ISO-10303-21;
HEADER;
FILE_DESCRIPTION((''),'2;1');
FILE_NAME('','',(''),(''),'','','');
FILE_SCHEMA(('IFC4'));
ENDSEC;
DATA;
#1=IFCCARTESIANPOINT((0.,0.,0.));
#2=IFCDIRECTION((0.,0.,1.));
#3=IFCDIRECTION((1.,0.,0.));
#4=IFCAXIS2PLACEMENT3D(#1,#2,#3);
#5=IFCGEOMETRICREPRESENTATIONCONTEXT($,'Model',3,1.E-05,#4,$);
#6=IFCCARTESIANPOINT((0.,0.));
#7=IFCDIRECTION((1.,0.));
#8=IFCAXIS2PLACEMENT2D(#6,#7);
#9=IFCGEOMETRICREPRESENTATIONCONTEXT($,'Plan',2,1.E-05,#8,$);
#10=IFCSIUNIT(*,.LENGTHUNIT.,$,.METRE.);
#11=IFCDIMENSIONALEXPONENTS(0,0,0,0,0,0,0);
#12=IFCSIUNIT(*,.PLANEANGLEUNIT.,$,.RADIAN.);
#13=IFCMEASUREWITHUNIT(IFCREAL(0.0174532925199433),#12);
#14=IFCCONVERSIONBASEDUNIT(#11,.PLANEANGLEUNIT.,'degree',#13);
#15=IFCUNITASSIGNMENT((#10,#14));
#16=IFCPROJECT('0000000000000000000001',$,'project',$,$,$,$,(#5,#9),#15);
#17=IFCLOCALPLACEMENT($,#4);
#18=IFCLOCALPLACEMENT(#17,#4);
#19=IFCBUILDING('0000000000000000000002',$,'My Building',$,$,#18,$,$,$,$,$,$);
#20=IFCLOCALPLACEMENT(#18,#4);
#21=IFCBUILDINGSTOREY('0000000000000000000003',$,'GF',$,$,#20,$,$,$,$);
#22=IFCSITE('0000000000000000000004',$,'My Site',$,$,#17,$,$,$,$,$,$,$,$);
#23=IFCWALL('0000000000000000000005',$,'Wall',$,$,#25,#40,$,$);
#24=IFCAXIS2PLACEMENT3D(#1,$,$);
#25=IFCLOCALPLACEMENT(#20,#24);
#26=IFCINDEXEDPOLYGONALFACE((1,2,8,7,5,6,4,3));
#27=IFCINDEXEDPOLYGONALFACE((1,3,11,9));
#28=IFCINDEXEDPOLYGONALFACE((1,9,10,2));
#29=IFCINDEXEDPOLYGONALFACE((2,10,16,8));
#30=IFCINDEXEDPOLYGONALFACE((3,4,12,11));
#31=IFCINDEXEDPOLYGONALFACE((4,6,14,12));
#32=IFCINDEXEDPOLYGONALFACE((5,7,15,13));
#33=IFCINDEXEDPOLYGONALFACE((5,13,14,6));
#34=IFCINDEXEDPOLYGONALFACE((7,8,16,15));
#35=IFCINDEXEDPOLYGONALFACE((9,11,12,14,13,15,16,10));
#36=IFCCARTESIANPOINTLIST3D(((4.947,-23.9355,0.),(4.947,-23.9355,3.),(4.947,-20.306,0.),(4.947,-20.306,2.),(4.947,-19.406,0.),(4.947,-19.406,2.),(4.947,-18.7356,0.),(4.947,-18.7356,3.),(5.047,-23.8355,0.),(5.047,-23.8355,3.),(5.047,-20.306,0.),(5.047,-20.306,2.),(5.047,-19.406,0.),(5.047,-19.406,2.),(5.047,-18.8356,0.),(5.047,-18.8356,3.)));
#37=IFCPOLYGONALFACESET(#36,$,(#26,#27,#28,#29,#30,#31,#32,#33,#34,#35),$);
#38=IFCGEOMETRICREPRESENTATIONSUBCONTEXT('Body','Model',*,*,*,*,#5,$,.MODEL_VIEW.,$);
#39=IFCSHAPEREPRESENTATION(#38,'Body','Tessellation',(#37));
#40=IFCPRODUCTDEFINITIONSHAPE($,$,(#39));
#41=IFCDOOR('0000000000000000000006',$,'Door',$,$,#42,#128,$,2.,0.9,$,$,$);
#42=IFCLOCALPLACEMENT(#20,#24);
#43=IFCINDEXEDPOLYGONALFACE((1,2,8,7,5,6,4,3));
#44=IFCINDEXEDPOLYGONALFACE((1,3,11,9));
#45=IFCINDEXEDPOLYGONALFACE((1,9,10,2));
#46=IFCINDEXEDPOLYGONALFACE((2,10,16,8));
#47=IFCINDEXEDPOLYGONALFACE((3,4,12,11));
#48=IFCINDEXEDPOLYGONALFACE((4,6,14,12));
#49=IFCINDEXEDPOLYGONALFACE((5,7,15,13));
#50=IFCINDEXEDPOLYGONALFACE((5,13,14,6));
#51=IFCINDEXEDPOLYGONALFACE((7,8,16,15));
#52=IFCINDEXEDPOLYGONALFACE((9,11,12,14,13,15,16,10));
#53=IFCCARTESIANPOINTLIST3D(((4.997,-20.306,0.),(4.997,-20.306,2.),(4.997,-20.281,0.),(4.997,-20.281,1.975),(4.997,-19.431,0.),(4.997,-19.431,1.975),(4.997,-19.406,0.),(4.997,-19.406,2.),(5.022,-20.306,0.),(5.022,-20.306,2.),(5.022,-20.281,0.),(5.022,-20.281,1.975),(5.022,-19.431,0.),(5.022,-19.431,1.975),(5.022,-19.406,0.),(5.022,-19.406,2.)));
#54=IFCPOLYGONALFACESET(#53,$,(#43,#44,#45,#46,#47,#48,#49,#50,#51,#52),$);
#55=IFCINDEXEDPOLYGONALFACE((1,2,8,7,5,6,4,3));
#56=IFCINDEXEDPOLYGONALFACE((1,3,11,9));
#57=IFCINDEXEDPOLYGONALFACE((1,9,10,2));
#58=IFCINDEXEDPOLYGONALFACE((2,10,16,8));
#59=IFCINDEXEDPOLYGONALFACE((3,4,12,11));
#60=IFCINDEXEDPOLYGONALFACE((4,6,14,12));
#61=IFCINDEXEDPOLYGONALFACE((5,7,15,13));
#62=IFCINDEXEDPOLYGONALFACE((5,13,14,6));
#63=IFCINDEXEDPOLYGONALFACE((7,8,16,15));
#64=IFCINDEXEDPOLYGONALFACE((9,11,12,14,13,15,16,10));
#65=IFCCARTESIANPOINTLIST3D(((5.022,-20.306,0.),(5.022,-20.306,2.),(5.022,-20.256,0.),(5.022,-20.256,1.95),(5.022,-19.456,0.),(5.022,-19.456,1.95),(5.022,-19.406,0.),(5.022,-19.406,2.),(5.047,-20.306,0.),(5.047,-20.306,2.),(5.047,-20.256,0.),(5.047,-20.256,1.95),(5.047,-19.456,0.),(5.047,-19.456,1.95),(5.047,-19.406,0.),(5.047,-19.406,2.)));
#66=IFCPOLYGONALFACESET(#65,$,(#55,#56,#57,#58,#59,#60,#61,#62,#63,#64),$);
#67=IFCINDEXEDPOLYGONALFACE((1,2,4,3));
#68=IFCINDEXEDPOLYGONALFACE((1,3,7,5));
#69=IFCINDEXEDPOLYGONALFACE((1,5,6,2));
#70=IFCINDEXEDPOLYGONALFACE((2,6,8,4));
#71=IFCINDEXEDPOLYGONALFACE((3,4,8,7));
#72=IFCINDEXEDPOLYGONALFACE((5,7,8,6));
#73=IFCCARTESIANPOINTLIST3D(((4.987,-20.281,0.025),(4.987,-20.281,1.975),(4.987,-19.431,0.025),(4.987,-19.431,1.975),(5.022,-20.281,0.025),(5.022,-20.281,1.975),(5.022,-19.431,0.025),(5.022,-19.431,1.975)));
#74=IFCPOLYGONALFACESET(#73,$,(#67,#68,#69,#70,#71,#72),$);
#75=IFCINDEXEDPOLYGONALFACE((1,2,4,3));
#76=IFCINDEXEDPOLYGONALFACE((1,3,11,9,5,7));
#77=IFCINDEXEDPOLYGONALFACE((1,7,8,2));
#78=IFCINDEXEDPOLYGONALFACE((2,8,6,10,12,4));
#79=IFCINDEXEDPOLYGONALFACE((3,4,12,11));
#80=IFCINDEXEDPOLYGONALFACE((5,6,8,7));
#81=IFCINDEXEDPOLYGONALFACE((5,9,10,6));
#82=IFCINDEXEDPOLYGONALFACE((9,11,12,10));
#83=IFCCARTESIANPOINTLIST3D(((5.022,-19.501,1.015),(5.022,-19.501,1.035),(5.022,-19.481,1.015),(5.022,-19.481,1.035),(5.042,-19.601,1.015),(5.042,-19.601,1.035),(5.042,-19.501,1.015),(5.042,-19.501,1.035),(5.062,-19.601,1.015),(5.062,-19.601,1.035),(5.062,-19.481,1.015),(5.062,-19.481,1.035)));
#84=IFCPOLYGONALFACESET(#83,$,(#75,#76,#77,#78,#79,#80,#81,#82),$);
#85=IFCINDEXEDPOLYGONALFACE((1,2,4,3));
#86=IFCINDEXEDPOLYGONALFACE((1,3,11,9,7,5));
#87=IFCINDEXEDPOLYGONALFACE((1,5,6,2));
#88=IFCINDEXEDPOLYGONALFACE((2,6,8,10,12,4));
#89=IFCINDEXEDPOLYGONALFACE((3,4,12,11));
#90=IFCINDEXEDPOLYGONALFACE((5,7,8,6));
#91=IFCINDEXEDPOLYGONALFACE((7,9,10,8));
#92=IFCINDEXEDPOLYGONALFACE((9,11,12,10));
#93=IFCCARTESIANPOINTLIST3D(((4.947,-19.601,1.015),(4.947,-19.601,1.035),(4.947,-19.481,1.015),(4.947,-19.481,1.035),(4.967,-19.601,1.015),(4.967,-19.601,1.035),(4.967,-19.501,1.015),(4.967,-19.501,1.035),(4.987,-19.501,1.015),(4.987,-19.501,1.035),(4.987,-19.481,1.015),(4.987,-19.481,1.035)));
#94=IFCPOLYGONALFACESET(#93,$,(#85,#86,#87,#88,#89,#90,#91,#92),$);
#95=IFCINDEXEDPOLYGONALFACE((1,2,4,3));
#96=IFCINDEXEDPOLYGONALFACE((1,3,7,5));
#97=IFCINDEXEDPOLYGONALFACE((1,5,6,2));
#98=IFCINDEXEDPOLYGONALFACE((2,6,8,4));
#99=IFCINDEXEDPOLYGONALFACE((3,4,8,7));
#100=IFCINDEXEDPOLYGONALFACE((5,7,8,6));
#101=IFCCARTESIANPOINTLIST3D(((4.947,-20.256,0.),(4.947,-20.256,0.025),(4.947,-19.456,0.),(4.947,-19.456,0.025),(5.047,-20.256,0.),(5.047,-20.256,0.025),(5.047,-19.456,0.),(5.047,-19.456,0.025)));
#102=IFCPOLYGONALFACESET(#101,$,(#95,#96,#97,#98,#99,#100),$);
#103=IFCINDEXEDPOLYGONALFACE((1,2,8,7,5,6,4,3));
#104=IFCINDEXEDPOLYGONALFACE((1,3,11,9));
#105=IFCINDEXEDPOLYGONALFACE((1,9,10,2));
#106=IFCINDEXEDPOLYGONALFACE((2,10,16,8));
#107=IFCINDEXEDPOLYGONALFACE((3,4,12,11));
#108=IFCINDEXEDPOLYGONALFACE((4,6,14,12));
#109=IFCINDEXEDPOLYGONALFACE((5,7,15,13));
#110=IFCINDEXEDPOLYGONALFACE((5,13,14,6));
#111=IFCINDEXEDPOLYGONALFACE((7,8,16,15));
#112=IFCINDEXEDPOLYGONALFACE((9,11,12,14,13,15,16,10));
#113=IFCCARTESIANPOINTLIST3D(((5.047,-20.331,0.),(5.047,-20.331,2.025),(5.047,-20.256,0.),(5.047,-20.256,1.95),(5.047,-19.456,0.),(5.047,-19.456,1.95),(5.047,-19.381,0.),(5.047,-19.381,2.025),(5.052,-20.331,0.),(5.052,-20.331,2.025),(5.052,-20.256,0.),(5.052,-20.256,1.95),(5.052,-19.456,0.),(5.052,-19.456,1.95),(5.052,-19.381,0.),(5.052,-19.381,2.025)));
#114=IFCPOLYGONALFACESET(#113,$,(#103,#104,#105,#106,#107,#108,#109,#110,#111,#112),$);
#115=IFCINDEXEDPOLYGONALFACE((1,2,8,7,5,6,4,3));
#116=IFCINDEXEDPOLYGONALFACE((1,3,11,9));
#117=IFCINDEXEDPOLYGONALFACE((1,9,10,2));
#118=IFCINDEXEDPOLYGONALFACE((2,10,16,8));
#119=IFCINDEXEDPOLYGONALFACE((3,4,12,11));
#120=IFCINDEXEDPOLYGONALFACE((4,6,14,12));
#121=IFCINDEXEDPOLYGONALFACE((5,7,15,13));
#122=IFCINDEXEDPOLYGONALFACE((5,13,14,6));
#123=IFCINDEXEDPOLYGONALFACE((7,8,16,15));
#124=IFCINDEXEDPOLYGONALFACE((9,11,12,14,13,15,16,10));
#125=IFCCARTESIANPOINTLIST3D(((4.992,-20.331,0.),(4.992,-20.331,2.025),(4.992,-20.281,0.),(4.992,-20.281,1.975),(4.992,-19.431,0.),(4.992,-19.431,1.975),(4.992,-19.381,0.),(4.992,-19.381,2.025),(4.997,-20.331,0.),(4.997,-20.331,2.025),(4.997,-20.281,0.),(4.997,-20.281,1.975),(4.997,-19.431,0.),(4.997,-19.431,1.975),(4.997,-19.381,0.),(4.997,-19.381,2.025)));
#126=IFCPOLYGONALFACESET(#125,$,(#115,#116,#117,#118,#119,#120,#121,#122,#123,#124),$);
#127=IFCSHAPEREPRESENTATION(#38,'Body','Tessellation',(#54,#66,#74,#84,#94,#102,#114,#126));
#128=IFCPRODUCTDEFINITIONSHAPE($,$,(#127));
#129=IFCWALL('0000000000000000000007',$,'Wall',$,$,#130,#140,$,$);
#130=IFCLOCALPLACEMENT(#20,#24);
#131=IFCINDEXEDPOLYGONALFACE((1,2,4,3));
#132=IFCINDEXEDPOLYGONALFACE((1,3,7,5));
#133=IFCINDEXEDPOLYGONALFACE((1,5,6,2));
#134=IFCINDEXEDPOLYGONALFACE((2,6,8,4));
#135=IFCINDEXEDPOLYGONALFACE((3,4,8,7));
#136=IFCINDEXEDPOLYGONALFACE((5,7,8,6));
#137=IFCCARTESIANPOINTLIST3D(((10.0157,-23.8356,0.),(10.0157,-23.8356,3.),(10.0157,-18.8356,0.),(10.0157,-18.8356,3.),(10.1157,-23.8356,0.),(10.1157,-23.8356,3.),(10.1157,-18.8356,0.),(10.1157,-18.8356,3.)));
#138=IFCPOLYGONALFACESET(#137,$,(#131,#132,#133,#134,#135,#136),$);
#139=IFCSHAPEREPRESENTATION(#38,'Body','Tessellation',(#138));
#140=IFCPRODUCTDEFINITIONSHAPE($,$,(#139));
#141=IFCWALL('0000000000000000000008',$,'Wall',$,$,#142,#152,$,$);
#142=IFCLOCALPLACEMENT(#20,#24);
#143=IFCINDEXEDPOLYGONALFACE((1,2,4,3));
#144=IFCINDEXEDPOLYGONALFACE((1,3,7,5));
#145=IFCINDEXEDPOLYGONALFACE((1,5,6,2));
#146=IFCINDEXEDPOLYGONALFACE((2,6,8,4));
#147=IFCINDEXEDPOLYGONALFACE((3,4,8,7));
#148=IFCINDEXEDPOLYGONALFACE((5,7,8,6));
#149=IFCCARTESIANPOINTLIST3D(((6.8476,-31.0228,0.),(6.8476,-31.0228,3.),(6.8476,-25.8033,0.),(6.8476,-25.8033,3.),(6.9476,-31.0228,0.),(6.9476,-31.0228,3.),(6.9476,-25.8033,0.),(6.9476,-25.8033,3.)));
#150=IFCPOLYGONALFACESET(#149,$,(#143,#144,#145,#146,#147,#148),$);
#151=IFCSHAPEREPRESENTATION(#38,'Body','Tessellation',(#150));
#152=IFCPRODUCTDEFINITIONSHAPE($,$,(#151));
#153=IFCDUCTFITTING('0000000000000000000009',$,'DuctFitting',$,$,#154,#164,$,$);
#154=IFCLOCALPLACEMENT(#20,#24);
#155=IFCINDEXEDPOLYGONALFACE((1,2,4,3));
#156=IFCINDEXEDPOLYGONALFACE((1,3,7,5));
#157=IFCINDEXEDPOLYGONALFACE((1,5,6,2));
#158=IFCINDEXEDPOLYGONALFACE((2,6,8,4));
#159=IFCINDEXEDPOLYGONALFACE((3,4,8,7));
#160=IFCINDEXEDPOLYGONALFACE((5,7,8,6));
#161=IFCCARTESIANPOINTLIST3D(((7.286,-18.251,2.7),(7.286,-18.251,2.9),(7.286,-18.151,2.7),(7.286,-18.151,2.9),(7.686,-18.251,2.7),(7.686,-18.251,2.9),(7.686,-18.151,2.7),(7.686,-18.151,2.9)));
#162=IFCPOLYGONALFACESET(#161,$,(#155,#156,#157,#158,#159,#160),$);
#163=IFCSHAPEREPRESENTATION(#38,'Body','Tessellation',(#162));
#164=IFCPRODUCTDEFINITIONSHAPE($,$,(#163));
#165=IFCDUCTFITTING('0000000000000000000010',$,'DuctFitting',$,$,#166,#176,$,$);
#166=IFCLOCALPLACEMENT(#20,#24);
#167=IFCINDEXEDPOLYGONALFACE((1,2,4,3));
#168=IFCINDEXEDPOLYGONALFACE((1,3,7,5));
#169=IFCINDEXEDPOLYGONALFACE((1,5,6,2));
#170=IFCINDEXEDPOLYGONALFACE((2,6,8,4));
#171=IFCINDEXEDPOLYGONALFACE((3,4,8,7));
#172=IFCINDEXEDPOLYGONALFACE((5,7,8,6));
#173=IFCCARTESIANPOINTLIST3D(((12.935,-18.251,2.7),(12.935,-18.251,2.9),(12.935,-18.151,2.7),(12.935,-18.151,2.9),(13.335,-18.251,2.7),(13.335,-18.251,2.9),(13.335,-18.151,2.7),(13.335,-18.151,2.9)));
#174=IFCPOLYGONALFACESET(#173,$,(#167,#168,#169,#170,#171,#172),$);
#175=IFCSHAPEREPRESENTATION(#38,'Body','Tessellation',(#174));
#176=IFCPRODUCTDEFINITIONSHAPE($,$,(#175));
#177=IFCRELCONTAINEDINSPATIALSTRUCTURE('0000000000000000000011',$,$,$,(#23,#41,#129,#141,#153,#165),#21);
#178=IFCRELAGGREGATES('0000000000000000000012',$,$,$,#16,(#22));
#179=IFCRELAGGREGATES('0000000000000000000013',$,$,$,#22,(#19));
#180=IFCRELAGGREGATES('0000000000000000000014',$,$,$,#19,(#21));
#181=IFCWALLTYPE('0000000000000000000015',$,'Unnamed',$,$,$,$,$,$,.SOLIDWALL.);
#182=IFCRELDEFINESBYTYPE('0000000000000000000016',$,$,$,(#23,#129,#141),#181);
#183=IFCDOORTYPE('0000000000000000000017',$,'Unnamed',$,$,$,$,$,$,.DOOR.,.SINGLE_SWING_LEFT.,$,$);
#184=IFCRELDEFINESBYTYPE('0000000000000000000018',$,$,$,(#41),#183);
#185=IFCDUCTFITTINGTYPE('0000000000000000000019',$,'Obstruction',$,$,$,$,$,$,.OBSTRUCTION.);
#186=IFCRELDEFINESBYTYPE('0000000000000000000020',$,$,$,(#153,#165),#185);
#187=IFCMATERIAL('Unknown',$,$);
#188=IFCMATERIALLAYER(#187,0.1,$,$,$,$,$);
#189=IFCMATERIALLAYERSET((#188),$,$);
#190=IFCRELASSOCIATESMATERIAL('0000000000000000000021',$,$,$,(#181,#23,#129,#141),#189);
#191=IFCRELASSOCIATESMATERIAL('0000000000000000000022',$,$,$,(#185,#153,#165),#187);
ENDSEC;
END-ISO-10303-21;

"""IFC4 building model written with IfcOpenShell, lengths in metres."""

from ifc_helpers import new_model, entity, si_unit, converted_unit, frame, origin_with_axes, origin_2d_with_axis, place, context, subcontext, project, spatial, line, indexed_curve, rectangle, outline, extrude, shape, source, transform, mapped, material, layer, layer_set, layer_usage, material_profile, profile_set, profile_usage, type_object, type_shapes, element, fill, save


model = new_model("IFC4")

# Units and contexts
model_context = context("Model", 3, precision=1e-05, world=origin_with_axes())
plan_context = context("Plan", 2, precision=1e-05, world=origin_2d_with_axis())
body_context_1 = subcontext(model_context, "Body", "Model", "MODEL_VIEW")
body_context_2 = subcontext(plan_context, "Body", "Plan", "PLAN_VIEW")
ifc_project = project(units=[si_unit("LENGTHUNIT", "METRE"), converted_unit("PLANEANGLEUNIT", "degree", entity("IfcReal", 0.0174532925199433), si_unit("PLANEANGLEUNIT", "RADIAN"), dimensions=[0, 0, 0, 0, 0, 0, 0])], contexts=[model_context, plan_context])

# Site, building, storey
site_placement = place(None, origin_with_axes())
site = spatial("IfcSite", under=ifc_project, at=site_placement, Name="My Site")
building_placement = place(site_placement, origin_with_axes())
building = spatial("IfcBuilding", under=site, at=building_placement, Name="My Building")
storey_placement = place(building_placement, origin_with_axes())
storey = spatial("IfcBuildingStorey", under=building, at=storey_placement, Name="GF")

# Shared definitions
ifc_material = material(Name="Unknown")

# Shared definitions
ifc_layer_1 = layer(ifc_material, 0.1)
ifc_layer_set_1 = layer_set([ifc_layer_1])
wall_type = type_object("IfcWallType", Name="Unnamed", PredefinedType="SOLIDWALL", material=ifc_layer_set_1)

# Shared definitions
shared_shape_1 = source(origin_with_axes(), body_context_1, "Body", "SweptSolid", [
    extrude(outline(indexed_curve([(0.0, 0.0), (0.9, 0.0), (0.9, 2.0), (0.0, 2.0)], segments=[line(1, 2, 3, 4, 1)])), frame((0.0, -0.6, 0.0), z_axis=(0.0, -1.0, 0.0), x_axis=(1.0, 0.0, 0.0)), (0.0, 0.0, -1.0), 1.2),
])
door_type = type_object("IfcDoorType", Name="Unnamed", OperationType="SINGLE_SWING_LEFT", PredefinedType="DOOR")
shared_shape_2 = source(origin_with_axes(), body_context_1, "Body", "SweptSolid", [
    extrude(outline(indexed_curve([(0.0, 0.0), (0.0, 2.0), (0.9, 2.0), (0.9, 0.0), (0.875, 0.0), (0.875, 1.975), (0.025, 1.975), (0.025, 0.0)], segments=[line(1, 2, 3, 4, 5, 6, 7, 8, 1)])), frame((0.0, 0.025, 0.0), z_axis=(0.0, -1.0, 0.0), x_axis=(1.0, 0.0, 0.0)), (0.0, 0.0, -1.0), 0.025),
    extrude(outline(indexed_curve([(0.0, 0.0), (0.0, 2.0), (0.9, 2.0), (0.9, 0.0), (0.85, 0.0), (0.85, 1.95), (0.05, 1.95), (0.05, 0.0)], segments=[line(1, 2, 3, 4, 5, 6, 7, 8, 1)])), frame((0.0, 0.0, 0.0), z_axis=(0.0, -1.0, 0.0), x_axis=(1.0, 0.0, 0.0)), (0.0, 0.0, -1.0), 0.025),
    extrude(outline(indexed_curve([(0.0, 0.0), (0.85, 0.0), (0.85, 0.035), (0.0, 0.035)], segments=[line(1, 2, 3, 4, 1)])), frame((0.025, 0.025, 0.025), z_axis=(0.0, 0.0, 1.0), x_axis=(1.0, 0.0, 0.0)), (0.0, 0.0, 1.0), 1.95),
    extrude(outline(indexed_curve([(0.0, 0.0), (0.0, -0.04), (-0.12, -0.04), (-0.12, -0.02), (-0.02, -0.02), (-0.02, 0.0)], segments=[line(1, 2, 3, 4, 5, 6, 1)])), frame((0.825, 0.025, 1.015), z_axis=(0.0, 0.0, 1.0), x_axis=(1.0, 0.0, 0.0)), (0.0, 0.0, 1.0), 0.02),
    extrude(outline(indexed_curve([(0.0, 0.0), (0.0, 0.04), (-0.12, 0.04), (-0.12, 0.02), (-0.02, 0.02), (-0.02, 0.0)], segments=[line(1, 2, 3, 4, 5, 6, 1)])), frame((0.825, 0.06, 1.015), z_axis=(0.0, 0.0, 1.0), x_axis=(1.0, 0.0, 0.0)), (0.0, 0.0, 1.0), 0.02),
    extrude(outline(indexed_curve([(0.0, 0.0), (0.8, 0.0), (0.8, 0.1), (0.0, 0.1)], segments=[line(1, 2, 3, 4, 1)])), frame((0.05, 0.0, 0.0), z_axis=(0.0, 0.0, 1.0), x_axis=(1.0, 0.0, 0.0)), (0.0, 0.0, 1.0), 0.025),
    extrude(outline(indexed_curve([(0.0, 0.0), (0.0, 2.025), (0.95, 2.025), (0.95, 0.0), (0.875, 0.0), (0.875, 1.95), (0.075, 1.95), (0.075, 0.0)], segments=[line(1, 2, 3, 4, 5, 6, 7, 8, 1)])), frame((-0.025, -0.005, 0.0), z_axis=(0.0, -1.0, 0.0), x_axis=(1.0, 0.0, 0.0)), (0.0, 0.0, -1.0), 0.005),
    extrude(outline(indexed_curve([(0.0, 0.0), (0.0, 2.025), (0.95, 2.025), (0.95, 0.0), (0.9, 0.0), (0.9, 1.975), (0.05, 1.975), (0.05, 0.0)], segments=[line(1, 2, 3, 4, 5, 6, 7, 8, 1)])), frame((-0.025, 0.05, 0.0), z_axis=(0.0, -1.0, 0.0), x_axis=(1.0, 0.0, 0.0)), (0.0, 0.0, -1.0), 0.005),
])
shared_shape_3 = source(origin_with_axes(), body_context_2, "Body", "Curve2D", [
    entity("IfcIndexedPolyCurve", entity("IfcCartesianPointList2D", [[0.0, 0.0], [0.0, 0.05], [0.025, 0.05], [0.025, 0.025], [0.05, 0.025], [0.05, 0.0]]), [entity("IfcLineIndex", [1, 2, 3, 4, 5, 6, 1])]),
    entity("IfcIndexedPolyCurve", entity("IfcCartesianPointList2D", [[0.9, 0.0], [0.9, 0.05], [0.875, 0.05], [0.875, 0.025], [0.85, 0.025], [0.85, 0.0]]), [entity("IfcLineIndex", [1, 2, 3, 4, 5, 6, 1])]),
    entity("IfcTrimmedCurve", entity("IfcEllipse", entity("IfcAxis2Placement2D", entity("IfcCartesianPoint", [0.06, 0.05]), entity("IfcDirection", [1.0, 0.0])), 0.815, 0.85), [entity("IfcCartesianPoint", [0.875, 0.05])], [entity("IfcCartesianPoint", [0.06, 0.9])], True, "CARTESIAN"),
    entity("IfcIndexedPolyCurve", entity("IfcCartesianPointList2D", [[0.025, 0.05], [0.06, 0.05], [0.06, 0.9], [0.025, 0.9]]), [entity("IfcLineIndex", [1, 2, 3, 4, 1])]),
])
type_shapes(door_type, [shared_shape_2, shared_shape_3])

# Wall, opening, door
ifc_layer_usage_1 = layer_usage(ifc_layer_set_1, "AXIS2", "POSITIVE", 0.0)
wall_1_placement = place(storey_placement, frame((5.047, -23.8355, 0.0), z_axis=(0.0, 0.0, 1.0), x_axis=(0.0, 1.0, 0.0)))
wall_1 = element("IfcWall", 1, at=wall_1_placement, inside=storey, type_object=wall_type, material=ifc_layer_usage_1, Name="Wall", context=body_context_1, shape_type="SweptSolid", body=[
    extrude(outline(indexed_curve([(0.0, 0.0), (-0.1, 0.1), (5.1, 0.1), (5.0, 0.0)], segments=[line(1, 2, 3, 4, 1)])), origin_with_axes(), (0.0, 0.0, 1.0), 3.0),
])
opening_1_placement = place(wall_1_placement, frame((3.5295, 0.0, 0.0), z_axis=(0.0, 0.0, 1.0), x_axis=(1.0, 0.0, 0.0)))
opening_1 = element("IfcOpeningElement", 2, at=opening_1_placement, cuts=wall_1, PredefinedType="OPENING", context=body_context_1, shape_type="MappedRepresentation", body=[
    mapped(shared_shape_1, transform((0.0, 0.0, 0.0), x_axis=(1.0, 0.0, 0.0), y_axis=(0.0, 1.0, 0.0), z_axis=(0.0, 0.0, 1.0), scale=1.0)),
])
door_1_placement = place(opening_1_placement, frame((0.0, 0.0, 0.0), z_axis=(0.0, 0.0, 1.0), x_axis=(1.0, 0.0, 0.0)))
door_1 = element("IfcDoor", 3, at=door_1_placement, inside=storey, type_object=door_type, Name="Door", OverallHeight=2.0, OverallWidth=0.9, shapes=[
    shape(body_context_1, "Body", "MappedRepresentation", [mapped(shared_shape_2, transform((0.0, 0.0, 0.0), x_axis=(1.0, 0.0, 0.0), y_axis=(0.0, 1.0, 0.0), z_axis=(0.0, 0.0, 1.0), scale=1.0))]),
    shape(body_context_2, "Body", "MappedRepresentation", [mapped(shared_shape_3, transform((0.0, 0.0, 0.0), x_axis=(1.0, 0.0, 0.0), y_axis=(0.0, 1.0, 0.0), z_axis=(0.0, 0.0, 1.0), scale=1.0))]),
])
fill(opening_1, door_1)

# Walls
ifc_layer_usage_2 = layer_usage(ifc_layer_set_1, "AXIS2", "POSITIVE", 0.0)
wall_2_placement = place(storey_placement, frame((10.0157, -18.8356, 0.0), z_axis=(0.0, 0.0, 1.0), x_axis=(0.0, -1.0, 0.0)))
element("IfcWall", 4, at=wall_2_placement, inside=storey, type_object=wall_type, material=ifc_layer_usage_2, Name="Wall", context=body_context_1, shape_type="SweptSolid", body=[
    extrude(outline(indexed_curve([(0.0, 0.0), (0.0, 0.1), (5.0, 0.1), (5.0, 0.0)], segments=[line(1, 2, 3, 4, 1)])), origin_with_axes(), (0.0, 0.0, 1.0), 3.0),
])
ifc_layer_usage_3 = layer_usage(ifc_layer_set_1, "AXIS2", "POSITIVE", 0.0)
wall_3_placement = place(storey_placement, frame((6.8476, -25.8033, 0.0), z_axis=(0.0, 0.0, 1.0), x_axis=(0.0, -1.0, 0.0)))
element("IfcWall", 5, at=wall_3_placement, inside=storey, type_object=wall_type, material=ifc_layer_usage_3, Name="Wall", context=body_context_1, shape_type="SweptSolid", body=[
    extrude(outline(indexed_curve([(0.0, 0.0), (0.0, 0.1), (5.2195, 0.1), (5.2195, 0.0)], segments=[line(1, 2, 3, 4, 1)])), origin_with_axes(), (0.0, 0.0, 1.0), 3.0),
])

# Duct fittings
ifc_material_profile = material_profile(ifc_material, rectangle(XDim=0.4, YDim=0.2))
ifc_profile_set = profile_set([ifc_material_profile])
ifc_profile_usage_1 = profile_usage(ifc_profile_set, cardinal=5)
duct_fitting_type = type_object("IfcDuctFittingType", Name="Obstruction", PredefinedType="OBSTRUCTION", material=ifc_profile_set)
duct_fitting_1_placement = place(storey_placement, frame((7.486, -18.251, 2.8), z_axis=(0.0, 1.0, 0.0), x_axis=(-1.0, 0.0, 0.0)))
element("IfcDuctFitting", 6, at=duct_fitting_1_placement, inside=storey, type_object=duct_fitting_type, material=ifc_profile_usage_1, Name="DuctFitting", context=body_context_1, shape_type="SweptSolid", body=[
    extrude(rectangle(XDim=0.4, YDim=0.2), origin_with_axes(), (0.0, 0.0, 1.0), 0.1),
])
ifc_profile_usage_2 = profile_usage(ifc_profile_set, cardinal=5)
duct_fitting_2_placement = place(storey_placement, frame((13.135, -18.251, 2.8), z_axis=(0.0, 1.0, 0.0), x_axis=(-1.0, 0.0, 0.0)))
element("IfcDuctFitting", 7, at=duct_fitting_2_placement, inside=storey, type_object=duct_fitting_type, material=ifc_profile_usage_2, Name="DuctFitting", context=body_context_1, shape_type="SweptSolid", body=[
    extrude(rectangle(XDim=0.4, YDim=0.2), origin_with_axes(), (0.0, 0.0, 1.0), 0.1),
])

save(model, "model.ifc")
